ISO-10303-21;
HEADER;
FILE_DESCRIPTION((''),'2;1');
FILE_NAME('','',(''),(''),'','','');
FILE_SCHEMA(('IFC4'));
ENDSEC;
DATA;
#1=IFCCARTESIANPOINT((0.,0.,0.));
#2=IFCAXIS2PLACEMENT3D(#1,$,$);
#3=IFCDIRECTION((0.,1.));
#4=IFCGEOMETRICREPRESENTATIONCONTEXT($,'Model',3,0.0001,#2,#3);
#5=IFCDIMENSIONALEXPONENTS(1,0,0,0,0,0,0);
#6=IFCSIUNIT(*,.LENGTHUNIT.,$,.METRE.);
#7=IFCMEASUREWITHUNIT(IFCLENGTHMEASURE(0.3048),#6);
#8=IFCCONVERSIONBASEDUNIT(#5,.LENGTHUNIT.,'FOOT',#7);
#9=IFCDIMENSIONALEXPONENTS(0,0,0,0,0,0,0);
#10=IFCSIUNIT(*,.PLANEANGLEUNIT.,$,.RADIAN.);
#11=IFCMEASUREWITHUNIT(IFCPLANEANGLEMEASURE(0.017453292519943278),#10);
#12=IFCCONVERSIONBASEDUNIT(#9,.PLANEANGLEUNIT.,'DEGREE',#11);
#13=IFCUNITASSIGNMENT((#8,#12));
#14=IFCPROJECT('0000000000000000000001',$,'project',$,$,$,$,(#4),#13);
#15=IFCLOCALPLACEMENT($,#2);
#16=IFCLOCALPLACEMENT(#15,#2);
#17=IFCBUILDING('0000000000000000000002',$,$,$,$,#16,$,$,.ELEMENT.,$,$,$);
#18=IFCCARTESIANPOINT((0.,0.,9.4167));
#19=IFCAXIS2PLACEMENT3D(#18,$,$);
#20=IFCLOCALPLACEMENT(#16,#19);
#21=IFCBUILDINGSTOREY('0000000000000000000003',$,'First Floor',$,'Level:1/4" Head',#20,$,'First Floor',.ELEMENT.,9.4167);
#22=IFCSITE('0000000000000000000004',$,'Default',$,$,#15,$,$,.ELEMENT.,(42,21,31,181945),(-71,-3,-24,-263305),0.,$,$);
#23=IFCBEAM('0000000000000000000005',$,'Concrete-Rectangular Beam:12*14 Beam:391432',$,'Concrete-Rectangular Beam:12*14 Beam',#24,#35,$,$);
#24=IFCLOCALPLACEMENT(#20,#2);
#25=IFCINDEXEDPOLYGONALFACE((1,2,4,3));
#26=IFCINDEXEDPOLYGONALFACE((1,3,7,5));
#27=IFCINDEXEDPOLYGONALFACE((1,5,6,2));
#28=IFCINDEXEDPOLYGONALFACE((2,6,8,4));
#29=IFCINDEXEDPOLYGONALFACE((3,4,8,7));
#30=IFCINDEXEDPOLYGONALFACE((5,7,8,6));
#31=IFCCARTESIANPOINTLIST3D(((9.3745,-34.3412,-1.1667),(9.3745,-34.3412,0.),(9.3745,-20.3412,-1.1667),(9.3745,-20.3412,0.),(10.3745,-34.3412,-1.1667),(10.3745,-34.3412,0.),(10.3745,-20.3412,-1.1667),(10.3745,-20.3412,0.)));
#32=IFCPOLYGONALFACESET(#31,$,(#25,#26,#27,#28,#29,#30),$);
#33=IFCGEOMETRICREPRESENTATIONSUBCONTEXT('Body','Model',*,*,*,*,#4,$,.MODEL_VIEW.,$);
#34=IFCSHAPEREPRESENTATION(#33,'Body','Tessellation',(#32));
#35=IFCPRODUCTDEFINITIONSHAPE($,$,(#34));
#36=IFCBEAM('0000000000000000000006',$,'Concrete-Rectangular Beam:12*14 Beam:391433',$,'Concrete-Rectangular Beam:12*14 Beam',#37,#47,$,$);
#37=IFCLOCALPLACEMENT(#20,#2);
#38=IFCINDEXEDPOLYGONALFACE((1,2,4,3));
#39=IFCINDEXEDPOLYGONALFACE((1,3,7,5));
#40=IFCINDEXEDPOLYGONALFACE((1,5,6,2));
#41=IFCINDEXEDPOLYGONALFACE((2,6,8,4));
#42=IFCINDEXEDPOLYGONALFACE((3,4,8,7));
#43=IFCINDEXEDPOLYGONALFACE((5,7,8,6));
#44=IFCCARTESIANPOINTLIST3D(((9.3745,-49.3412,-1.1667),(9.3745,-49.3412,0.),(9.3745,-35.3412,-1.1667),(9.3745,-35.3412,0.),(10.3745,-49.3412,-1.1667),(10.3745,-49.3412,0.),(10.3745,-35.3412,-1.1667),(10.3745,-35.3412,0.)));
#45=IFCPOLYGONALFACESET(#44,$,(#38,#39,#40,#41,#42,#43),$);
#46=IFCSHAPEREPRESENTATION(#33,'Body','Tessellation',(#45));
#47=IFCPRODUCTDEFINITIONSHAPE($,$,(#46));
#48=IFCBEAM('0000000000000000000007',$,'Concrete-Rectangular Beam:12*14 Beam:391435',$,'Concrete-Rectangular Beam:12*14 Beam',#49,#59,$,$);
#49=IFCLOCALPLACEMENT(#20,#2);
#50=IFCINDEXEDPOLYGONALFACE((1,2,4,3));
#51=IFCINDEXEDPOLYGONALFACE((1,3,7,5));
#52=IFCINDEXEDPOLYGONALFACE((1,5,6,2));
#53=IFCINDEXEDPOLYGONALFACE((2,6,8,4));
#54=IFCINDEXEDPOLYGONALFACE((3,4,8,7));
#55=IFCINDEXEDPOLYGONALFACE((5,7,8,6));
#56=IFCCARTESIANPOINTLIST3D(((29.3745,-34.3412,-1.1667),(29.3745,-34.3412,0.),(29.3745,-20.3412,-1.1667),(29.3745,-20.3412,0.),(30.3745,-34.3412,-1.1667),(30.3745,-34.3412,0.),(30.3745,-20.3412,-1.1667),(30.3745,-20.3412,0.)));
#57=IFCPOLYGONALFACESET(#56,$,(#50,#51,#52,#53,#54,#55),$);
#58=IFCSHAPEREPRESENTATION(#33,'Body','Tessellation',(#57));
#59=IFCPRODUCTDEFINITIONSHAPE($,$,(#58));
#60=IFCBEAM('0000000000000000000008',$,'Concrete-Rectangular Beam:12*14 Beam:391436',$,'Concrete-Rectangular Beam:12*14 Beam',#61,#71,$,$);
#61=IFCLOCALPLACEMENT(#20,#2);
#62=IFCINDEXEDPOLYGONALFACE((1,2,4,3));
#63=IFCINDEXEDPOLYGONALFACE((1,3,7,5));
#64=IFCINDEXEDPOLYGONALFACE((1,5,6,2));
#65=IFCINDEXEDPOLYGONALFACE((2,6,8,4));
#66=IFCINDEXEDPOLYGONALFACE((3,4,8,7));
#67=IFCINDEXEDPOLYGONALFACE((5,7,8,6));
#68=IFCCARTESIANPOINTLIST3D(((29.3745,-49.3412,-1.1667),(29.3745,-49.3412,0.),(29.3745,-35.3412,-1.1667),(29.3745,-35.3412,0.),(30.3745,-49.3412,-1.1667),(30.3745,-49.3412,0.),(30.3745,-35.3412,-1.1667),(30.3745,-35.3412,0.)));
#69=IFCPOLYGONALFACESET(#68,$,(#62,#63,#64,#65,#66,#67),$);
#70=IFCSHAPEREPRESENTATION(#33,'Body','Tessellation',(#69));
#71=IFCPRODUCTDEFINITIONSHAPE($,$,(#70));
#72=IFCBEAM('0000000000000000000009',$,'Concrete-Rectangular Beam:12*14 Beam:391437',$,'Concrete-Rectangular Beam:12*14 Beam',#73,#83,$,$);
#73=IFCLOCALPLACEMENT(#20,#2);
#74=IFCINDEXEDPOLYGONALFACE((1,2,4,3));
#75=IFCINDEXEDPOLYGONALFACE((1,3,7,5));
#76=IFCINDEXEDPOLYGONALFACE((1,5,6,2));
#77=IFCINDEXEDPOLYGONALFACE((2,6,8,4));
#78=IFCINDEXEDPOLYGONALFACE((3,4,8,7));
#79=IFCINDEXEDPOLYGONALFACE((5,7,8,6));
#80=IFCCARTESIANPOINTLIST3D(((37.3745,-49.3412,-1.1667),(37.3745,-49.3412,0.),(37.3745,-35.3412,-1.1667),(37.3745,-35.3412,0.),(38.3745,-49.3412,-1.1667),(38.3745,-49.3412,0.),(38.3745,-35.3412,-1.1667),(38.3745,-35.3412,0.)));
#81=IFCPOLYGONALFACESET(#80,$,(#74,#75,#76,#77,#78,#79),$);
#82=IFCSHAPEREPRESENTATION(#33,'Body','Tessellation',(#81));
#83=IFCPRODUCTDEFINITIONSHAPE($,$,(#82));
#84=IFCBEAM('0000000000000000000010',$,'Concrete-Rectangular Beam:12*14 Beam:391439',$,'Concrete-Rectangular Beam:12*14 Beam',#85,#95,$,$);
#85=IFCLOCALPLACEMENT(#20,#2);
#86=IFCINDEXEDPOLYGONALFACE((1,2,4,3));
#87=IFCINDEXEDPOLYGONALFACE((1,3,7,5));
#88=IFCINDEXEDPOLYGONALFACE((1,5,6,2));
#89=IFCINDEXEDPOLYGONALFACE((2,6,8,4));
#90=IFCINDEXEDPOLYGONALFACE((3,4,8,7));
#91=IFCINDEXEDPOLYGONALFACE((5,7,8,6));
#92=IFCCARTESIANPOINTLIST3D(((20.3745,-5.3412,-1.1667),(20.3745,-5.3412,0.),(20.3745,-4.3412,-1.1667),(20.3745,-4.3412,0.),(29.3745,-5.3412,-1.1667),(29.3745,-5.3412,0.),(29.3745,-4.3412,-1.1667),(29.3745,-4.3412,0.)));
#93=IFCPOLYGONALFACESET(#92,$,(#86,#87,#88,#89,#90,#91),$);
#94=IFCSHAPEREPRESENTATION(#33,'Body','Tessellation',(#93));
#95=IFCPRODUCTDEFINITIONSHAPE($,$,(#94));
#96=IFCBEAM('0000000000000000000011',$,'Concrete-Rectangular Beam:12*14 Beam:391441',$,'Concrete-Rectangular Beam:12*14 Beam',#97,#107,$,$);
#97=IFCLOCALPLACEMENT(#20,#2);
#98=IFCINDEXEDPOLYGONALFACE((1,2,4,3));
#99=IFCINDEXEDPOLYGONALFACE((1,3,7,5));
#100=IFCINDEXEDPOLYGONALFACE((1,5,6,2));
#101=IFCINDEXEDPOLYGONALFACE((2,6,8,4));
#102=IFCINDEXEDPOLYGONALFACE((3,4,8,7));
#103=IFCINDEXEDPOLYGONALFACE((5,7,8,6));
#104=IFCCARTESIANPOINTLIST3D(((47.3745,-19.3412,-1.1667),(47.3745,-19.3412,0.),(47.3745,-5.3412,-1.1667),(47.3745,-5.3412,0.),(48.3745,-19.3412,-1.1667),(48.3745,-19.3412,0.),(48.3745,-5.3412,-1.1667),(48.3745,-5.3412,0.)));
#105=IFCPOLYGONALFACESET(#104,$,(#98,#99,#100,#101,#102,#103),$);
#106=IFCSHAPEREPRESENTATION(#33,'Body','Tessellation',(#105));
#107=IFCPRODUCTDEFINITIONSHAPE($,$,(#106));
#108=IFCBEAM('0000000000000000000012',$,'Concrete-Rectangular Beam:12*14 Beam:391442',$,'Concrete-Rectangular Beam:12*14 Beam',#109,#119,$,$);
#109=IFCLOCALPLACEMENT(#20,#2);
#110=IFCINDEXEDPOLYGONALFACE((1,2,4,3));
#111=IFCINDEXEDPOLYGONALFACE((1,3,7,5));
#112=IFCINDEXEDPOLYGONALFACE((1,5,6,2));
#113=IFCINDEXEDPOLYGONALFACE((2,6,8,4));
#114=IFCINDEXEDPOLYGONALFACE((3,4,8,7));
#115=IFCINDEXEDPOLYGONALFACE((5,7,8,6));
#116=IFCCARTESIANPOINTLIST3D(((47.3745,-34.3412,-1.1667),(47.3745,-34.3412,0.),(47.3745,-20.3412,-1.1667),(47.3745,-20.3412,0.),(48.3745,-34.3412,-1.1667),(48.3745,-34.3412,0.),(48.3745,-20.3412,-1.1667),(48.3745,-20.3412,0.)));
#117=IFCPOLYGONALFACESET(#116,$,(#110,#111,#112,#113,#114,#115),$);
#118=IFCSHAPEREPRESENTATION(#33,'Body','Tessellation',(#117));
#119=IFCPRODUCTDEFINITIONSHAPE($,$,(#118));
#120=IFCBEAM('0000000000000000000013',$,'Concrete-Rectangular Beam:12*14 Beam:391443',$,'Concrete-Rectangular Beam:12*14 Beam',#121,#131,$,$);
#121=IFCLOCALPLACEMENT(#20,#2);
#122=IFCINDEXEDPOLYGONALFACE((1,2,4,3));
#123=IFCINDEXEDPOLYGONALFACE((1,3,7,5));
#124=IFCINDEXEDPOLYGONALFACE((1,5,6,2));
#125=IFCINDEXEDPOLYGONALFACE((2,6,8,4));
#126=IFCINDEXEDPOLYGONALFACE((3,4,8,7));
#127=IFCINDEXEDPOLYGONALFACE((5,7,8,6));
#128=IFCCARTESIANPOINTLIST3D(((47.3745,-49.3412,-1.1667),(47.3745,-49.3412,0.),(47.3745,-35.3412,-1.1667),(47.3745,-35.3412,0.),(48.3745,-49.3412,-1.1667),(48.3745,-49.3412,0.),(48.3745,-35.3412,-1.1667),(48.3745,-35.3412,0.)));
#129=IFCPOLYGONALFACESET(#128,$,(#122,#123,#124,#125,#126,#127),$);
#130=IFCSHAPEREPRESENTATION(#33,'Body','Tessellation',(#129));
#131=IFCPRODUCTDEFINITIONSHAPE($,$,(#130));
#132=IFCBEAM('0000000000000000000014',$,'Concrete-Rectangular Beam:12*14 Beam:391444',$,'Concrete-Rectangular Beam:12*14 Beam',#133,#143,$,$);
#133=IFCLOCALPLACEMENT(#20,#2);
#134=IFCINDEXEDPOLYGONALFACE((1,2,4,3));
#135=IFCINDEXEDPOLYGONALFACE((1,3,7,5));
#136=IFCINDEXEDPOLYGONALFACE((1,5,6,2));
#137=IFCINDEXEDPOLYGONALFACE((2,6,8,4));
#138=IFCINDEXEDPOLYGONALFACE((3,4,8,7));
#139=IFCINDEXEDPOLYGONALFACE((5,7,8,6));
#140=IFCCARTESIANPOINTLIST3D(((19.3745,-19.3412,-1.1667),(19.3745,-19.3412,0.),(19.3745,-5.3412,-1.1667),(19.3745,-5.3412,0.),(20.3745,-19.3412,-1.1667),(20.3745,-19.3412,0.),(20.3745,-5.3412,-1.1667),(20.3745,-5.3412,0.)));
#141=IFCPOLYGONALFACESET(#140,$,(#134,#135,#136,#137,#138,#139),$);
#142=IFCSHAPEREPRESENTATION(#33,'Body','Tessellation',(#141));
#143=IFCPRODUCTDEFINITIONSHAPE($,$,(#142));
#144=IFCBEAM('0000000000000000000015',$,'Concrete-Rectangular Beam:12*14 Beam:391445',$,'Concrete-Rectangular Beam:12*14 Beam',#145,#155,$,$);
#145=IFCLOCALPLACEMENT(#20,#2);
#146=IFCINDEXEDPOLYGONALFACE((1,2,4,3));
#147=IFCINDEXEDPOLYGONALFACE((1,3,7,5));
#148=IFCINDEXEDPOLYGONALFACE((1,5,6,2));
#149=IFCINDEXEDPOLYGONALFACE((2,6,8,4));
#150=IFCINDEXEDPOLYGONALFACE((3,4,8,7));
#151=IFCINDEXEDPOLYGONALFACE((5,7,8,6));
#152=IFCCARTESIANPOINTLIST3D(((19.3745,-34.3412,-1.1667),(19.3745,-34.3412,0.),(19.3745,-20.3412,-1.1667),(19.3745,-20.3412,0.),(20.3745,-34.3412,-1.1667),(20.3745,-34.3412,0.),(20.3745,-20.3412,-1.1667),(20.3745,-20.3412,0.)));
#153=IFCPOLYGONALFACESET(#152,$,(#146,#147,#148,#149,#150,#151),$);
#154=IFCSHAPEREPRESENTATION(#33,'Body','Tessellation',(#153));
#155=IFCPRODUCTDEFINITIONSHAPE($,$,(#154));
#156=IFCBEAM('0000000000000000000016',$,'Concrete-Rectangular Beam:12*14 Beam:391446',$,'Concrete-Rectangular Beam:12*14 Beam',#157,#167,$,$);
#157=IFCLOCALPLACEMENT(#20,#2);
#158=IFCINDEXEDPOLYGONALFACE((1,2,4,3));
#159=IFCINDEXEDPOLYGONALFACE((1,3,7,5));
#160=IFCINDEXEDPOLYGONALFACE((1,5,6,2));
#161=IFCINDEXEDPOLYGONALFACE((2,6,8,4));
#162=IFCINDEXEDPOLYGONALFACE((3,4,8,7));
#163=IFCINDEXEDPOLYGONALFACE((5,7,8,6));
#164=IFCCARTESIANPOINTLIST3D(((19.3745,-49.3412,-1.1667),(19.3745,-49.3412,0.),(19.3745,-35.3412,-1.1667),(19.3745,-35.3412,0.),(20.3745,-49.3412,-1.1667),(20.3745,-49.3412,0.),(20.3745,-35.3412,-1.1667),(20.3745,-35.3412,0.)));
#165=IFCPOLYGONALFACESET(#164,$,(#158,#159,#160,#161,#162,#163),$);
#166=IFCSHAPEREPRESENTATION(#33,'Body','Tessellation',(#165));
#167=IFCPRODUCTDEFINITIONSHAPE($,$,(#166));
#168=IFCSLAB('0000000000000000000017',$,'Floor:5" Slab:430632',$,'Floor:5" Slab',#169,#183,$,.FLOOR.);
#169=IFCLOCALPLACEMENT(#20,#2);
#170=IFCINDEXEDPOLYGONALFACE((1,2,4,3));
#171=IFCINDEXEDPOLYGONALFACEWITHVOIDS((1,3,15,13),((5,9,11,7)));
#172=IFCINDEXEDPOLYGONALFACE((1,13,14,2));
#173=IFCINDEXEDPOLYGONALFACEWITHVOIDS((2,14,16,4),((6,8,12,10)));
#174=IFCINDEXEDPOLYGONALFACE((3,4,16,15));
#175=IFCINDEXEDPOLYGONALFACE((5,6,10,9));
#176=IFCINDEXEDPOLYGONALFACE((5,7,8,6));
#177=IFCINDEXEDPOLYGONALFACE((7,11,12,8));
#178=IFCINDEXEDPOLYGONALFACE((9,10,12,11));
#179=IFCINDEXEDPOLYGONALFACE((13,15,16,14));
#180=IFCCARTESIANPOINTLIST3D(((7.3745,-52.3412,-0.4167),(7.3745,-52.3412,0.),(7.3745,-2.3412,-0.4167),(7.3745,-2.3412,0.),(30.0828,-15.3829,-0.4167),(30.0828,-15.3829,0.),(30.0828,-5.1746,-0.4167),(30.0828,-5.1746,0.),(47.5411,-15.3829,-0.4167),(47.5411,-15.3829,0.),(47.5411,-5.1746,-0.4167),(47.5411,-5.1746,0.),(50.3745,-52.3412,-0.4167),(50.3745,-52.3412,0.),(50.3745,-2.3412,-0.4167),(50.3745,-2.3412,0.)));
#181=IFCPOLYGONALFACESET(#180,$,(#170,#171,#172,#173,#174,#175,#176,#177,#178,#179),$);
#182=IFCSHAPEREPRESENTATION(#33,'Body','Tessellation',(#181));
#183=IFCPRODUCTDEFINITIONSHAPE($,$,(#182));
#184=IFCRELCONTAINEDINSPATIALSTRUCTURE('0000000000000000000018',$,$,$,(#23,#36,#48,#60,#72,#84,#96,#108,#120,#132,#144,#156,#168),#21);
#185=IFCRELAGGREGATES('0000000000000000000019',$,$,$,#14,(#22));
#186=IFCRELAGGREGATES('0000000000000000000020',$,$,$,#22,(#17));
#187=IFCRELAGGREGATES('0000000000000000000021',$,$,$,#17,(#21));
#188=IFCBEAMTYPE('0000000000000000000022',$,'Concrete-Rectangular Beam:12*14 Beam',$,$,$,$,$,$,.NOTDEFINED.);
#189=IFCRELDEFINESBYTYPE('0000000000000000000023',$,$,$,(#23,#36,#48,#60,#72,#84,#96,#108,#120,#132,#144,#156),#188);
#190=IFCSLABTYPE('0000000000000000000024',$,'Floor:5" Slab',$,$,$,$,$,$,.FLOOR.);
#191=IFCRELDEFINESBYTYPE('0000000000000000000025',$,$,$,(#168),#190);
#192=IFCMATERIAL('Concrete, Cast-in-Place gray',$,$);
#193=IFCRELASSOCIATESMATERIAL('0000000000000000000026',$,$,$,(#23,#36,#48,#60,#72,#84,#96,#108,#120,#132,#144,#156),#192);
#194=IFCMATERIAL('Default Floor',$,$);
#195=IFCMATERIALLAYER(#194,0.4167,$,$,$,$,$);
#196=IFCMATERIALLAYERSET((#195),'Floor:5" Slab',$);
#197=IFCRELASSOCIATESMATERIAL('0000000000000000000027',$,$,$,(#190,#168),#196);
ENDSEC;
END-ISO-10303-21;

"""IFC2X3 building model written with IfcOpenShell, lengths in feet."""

from ifc_helpers import new_model, entity, si_unit, converted_unit, direction, frame, frame_2d, origin, place, context, subcontext, project, spatial, rectangle, extrude, material, layer, layer_set, layer_usage, type_object, element, save


model = new_model("IFC2X3")

# Units and contexts
model_context = context("Model", 3, precision=0.0001, world=origin(), true_north=direction((0.0, 1.0)))
body_context = subcontext(model_context, "Body", "Model", "MODEL_VIEW")
ifc_project = project(units=[converted_unit("LENGTHUNIT", "FOOT", entity("IfcLengthMeasure", 0.3048), si_unit("LENGTHUNIT", "METRE"), dimensions=[1, 0, 0, 0, 0, 0, 0]), converted_unit("PLANEANGLEUNIT", "DEGREE", entity("IfcPlaneAngleMeasure", 0.017453292519943278), si_unit("PLANEANGLEUNIT", "RADIAN"), dimensions=[0, 0, 0, 0, 0, 0, 0])], contexts=[model_context])

# Site, building, storey
site_placement = place(None, origin())
site = spatial("IfcSite", under=ifc_project, at=site_placement, Name="Default", CompositionType="ELEMENT", RefLatitude=(42, 21, 31, 181945), RefLongitude=(-71, -3, -24, -263305), RefElevation=0.0)
building_placement = place(site_placement, origin())
building = spatial("IfcBuilding", under=site, at=building_placement, CompositionType="ELEMENT")
storey_placement = place(building_placement, frame((0.0, 0.0, 9.4167)))
storey = spatial("IfcBuildingStorey", under=building, at=storey_placement, Name="First Floor", ObjectType="Level:1/4\" Head", LongName="First Floor", CompositionType="ELEMENT", Elevation=9.4167)

# Beams
ifc_material_1 = material(Name="Concrete, Cast-in-Place gray")
beam_type = type_object("IfcBeamType", Name="Concrete-Rectangular Beam:12*14 Beam", PredefinedType="NOTDEFINED")
beam_1_placement = place(storey_placement, frame((9.8745, -19.8412, 0.0), z_axis=(0.0, 0.0, 1.0), x_axis=(0.0, -1.0, 0.0)))
element("IfcBeam", 1, at=beam_1_placement, inside=storey, type_object=beam_type, material=ifc_material_1, Name="Concrete-Rectangular Beam:12*14 Beam:391432", ObjectType="Concrete-Rectangular Beam:12*14 Beam", context=body_context, shape_type="SweptSolid", body=[
    extrude(rectangle(XDim=1.1667, YDim=1.0, at=frame_2d((0.0, 0.0), x_axis=(1.0, 0.0))), frame((0.5, 0.0, -0.5833), z_axis=(1.0, 0.0, 0.0), x_axis=(0.0, 0.0, -1.0)), (0.0, 0.0, 1.0), 14.0),
])
beam_2_placement = place(storey_placement, frame((9.8745, -34.8412, 0.0), z_axis=(0.0, 0.0, 1.0), x_axis=(0.0, -1.0, 0.0)))
element("IfcBeam", 2, at=beam_2_placement, inside=storey, type_object=beam_type, material=ifc_material_1, Name="Concrete-Rectangular Beam:12*14 Beam:391433", ObjectType="Concrete-Rectangular Beam:12*14 Beam", context=body_context, shape_type="SweptSolid", body=[
    extrude(rectangle(XDim=1.1667, YDim=1.0, at=frame_2d((0.0, 0.0), x_axis=(1.0, 0.0))), frame((0.5, 0.0, -0.5833), z_axis=(1.0, 0.0, 0.0), x_axis=(0.0, 0.0, -1.0)), (0.0, 0.0, 1.0), 14.0),
])
beam_3_placement = place(storey_placement, frame((29.8745, -19.8412, 0.0), z_axis=(0.0, 0.0, 1.0), x_axis=(0.0, -1.0, 0.0)))
element("IfcBeam", 3, at=beam_3_placement, inside=storey, type_object=beam_type, material=ifc_material_1, Name="Concrete-Rectangular Beam:12*14 Beam:391435", ObjectType="Concrete-Rectangular Beam:12*14 Beam", context=body_context, shape_type="SweptSolid", body=[
    extrude(rectangle(XDim=1.1667, YDim=1.0, at=frame_2d((0.0, 0.0), x_axis=(1.0, 0.0))), frame((0.5, 0.0, -0.5833), z_axis=(1.0, 0.0, 0.0), x_axis=(0.0, 0.0, -1.0)), (0.0, 0.0, 1.0), 14.0),
])
beam_4_placement = place(storey_placement, frame((29.8745, -34.8412, 0.0), z_axis=(0.0, 0.0, 1.0), x_axis=(0.0, -1.0, 0.0)))
element("IfcBeam", 4, at=beam_4_placement, inside=storey, type_object=beam_type, material=ifc_material_1, Name="Concrete-Rectangular Beam:12*14 Beam:391436", ObjectType="Concrete-Rectangular Beam:12*14 Beam", context=body_context, shape_type="SweptSolid", body=[
    extrude(rectangle(XDim=1.1667, YDim=1.0, at=frame_2d((0.0, 0.0), x_axis=(1.0, 0.0))), frame((0.5, 0.0, -0.5833), z_axis=(1.0, 0.0, 0.0), x_axis=(0.0, 0.0, -1.0)), (0.0, 0.0, 1.0), 14.0),
])
beam_5_placement = place(storey_placement, frame((37.8745, -34.8412, 0.0), z_axis=(0.0, 0.0, 1.0), x_axis=(0.0, -1.0, 0.0)))
element("IfcBeam", 5, at=beam_5_placement, inside=storey, type_object=beam_type, material=ifc_material_1, Name="Concrete-Rectangular Beam:12*14 Beam:391437", ObjectType="Concrete-Rectangular Beam:12*14 Beam", context=body_context, shape_type="SweptSolid", body=[
    extrude(rectangle(XDim=1.1667, YDim=1.0, at=frame_2d((0.0, 0.0), x_axis=(1.0, 0.0))), frame((0.5, 0.0, -0.5833), z_axis=(1.0, 0.0, 0.0), x_axis=(0.0, 0.0, -1.0)), (0.0, 0.0, 1.0), 14.0),
])
beam_6_placement = place(storey_placement, frame((19.8745, -4.8412, 0.0)))
element("IfcBeam", 6, at=beam_6_placement, inside=storey, type_object=beam_type, material=ifc_material_1, Name="Concrete-Rectangular Beam:12*14 Beam:391439", ObjectType="Concrete-Rectangular Beam:12*14 Beam", context=body_context, shape_type="SweptSolid", body=[
    extrude(rectangle(XDim=1.1667, YDim=1.0, at=frame_2d((0.0, 0.0), x_axis=(1.0, 0.0))), frame((0.5, 0.0, -0.5833), z_axis=(1.0, 0.0, 0.0), x_axis=(0.0, 0.0, -1.0)), (0.0, 0.0, 1.0), 9.0),
])
beam_7_placement = place(storey_placement, frame((47.8745, -4.8412, 0.0), z_axis=(0.0, 0.0, 1.0), x_axis=(0.0, -1.0, 0.0)))
element("IfcBeam", 7, at=beam_7_placement, inside=storey, type_object=beam_type, material=ifc_material_1, Name="Concrete-Rectangular Beam:12*14 Beam:391441", ObjectType="Concrete-Rectangular Beam:12*14 Beam", context=body_context, shape_type="SweptSolid", body=[
    extrude(rectangle(XDim=1.1667, YDim=1.0, at=frame_2d((0.0, 0.0), x_axis=(1.0, 0.0))), frame((0.5, 0.0, -0.5833), z_axis=(1.0, 0.0, 0.0), x_axis=(0.0, 0.0, -1.0)), (0.0, 0.0, 1.0), 14.0),
])
beam_8_placement = place(storey_placement, frame((47.8745, -19.8412, 0.0), z_axis=(0.0, 0.0, 1.0), x_axis=(0.0, -1.0, 0.0)))
element("IfcBeam", 8, at=beam_8_placement, inside=storey, type_object=beam_type, material=ifc_material_1, Name="Concrete-Rectangular Beam:12*14 Beam:391442", ObjectType="Concrete-Rectangular Beam:12*14 Beam", context=body_context, shape_type="SweptSolid", body=[
    extrude(rectangle(XDim=1.1667, YDim=1.0, at=frame_2d((0.0, 0.0), x_axis=(1.0, 0.0))), frame((0.5, 0.0, -0.5833), z_axis=(1.0, 0.0, 0.0), x_axis=(0.0, 0.0, -1.0)), (0.0, 0.0, 1.0), 14.0),
])
beam_9_placement = place(storey_placement, frame((47.8745, -34.8412, 0.0), z_axis=(0.0, 0.0, 1.0), x_axis=(0.0, -1.0, 0.0)))
element("IfcBeam", 9, at=beam_9_placement, inside=storey, type_object=beam_type, material=ifc_material_1, Name="Concrete-Rectangular Beam:12*14 Beam:391443", ObjectType="Concrete-Rectangular Beam:12*14 Beam", context=body_context, shape_type="SweptSolid", body=[
    extrude(rectangle(XDim=1.1667, YDim=1.0, at=frame_2d((0.0, 0.0), x_axis=(1.0, 0.0))), frame((0.5, 0.0, -0.5833), z_axis=(1.0, 0.0, 0.0), x_axis=(0.0, 0.0, -1.0)), (0.0, 0.0, 1.0), 14.0),
])
beam_10_placement = place(storey_placement, frame((19.8745, -4.8412, 0.0), z_axis=(0.0, 0.0, 1.0), x_axis=(0.0, -1.0, 0.0)))
element("IfcBeam", 10, at=beam_10_placement, inside=storey, type_object=beam_type, material=ifc_material_1, Name="Concrete-Rectangular Beam:12*14 Beam:391444", ObjectType="Concrete-Rectangular Beam:12*14 Beam", context=body_context, shape_type="SweptSolid", body=[
    extrude(rectangle(XDim=1.1667, YDim=1.0, at=frame_2d((0.0, 0.0), x_axis=(1.0, 0.0))), frame((0.5, 0.0, -0.5833), z_axis=(1.0, 0.0, 0.0), x_axis=(0.0, 0.0, -1.0)), (0.0, 0.0, 1.0), 14.0),
])
beam_11_placement = place(storey_placement, frame((19.8745, -19.8412, 0.0), z_axis=(0.0, 0.0, 1.0), x_axis=(0.0, -1.0, 0.0)))
element("IfcBeam", 11, at=beam_11_placement, inside=storey, type_object=beam_type, material=ifc_material_1, Name="Concrete-Rectangular Beam:12*14 Beam:391445", ObjectType="Concrete-Rectangular Beam:12*14 Beam", context=body_context, shape_type="SweptSolid", body=[
    extrude(rectangle(XDim=1.1667, YDim=1.0, at=frame_2d((0.0, 0.0), x_axis=(1.0, 0.0))), frame((0.5, 0.0, -0.5833), z_axis=(1.0, 0.0, 0.0), x_axis=(0.0, 0.0, -1.0)), (0.0, 0.0, 1.0), 14.0),
])
beam_12_placement = place(storey_placement, frame((19.8745, -34.8412, 0.0), z_axis=(0.0, 0.0, 1.0), x_axis=(0.0, -1.0, 0.0)))
element("IfcBeam", 12, at=beam_12_placement, inside=storey, type_object=beam_type, material=ifc_material_1, Name="Concrete-Rectangular Beam:12*14 Beam:391446", ObjectType="Concrete-Rectangular Beam:12*14 Beam", context=body_context, shape_type="SweptSolid", body=[
    extrude(rectangle(XDim=1.1667, YDim=1.0, at=frame_2d((0.0, 0.0), x_axis=(1.0, 0.0))), frame((0.5, 0.0, -0.5833), z_axis=(1.0, 0.0, 0.0), x_axis=(0.0, 0.0, -1.0)), (0.0, 0.0, 1.0), 14.0),
])

# Slab, opening
ifc_material_2 = material(Name="Default Floor")
ifc_layer_1 = layer(ifc_material_2, 0.4167)
ifc_layer_set_1 = layer_set([ifc_layer_1], Name="Floor:5\" Slab")
ifc_layer_usage_1 = layer_usage(ifc_layer_set_1, "AXIS3", "POSITIVE", 0.0)
slab_type = type_object("IfcSlabType", Name="Floor:5\" Slab", PredefinedType="FLOOR", material=ifc_layer_set_1)
slab_1_placement = place(storey_placement, frame((7.3745, -52.3412, -0.4167)))
slab_1 = element("IfcSlab", 13, at=slab_1_placement, inside=storey, type_object=slab_type, material=ifc_layer_usage_1, Name="Floor:5\" Slab:430632", ObjectType="Floor:5\" Slab", PredefinedType="FLOOR", context=body_context, shape_type="SweptSolid", body=[
    extrude(rectangle(XDim=50.0, YDim=43.0, at=frame_2d((0.0, 0.0), x_axis=(0.0, -1.0))), frame((21.5, 25.0, 0.4167), z_axis=(0.0, 0.0, -1.0), x_axis=(-1.0, 0.0, 0.0)), (0.0, 0.0, 1.0), 0.4167),
])
opening_placement = place(slab_1_placement, origin())
element("IfcOpeningElement", 14, at=opening_placement, cuts=slab_1, ObjectType="Opening", context=body_context, shape_type="SweptSolid", body=[
    extrude(rectangle(XDim=17.4583, YDim=10.2083, at=frame_2d((0.0, 0.0), x_axis=(1.0, 0.0))), frame((31.4375, 42.0625, 0.4167), z_axis=(0.0, 0.0, -1.0), x_axis=(1.0, 0.0, 0.0)), (0.0, 0.0, 1.0), 0.4167),
])

save(model, "model.ifc")
